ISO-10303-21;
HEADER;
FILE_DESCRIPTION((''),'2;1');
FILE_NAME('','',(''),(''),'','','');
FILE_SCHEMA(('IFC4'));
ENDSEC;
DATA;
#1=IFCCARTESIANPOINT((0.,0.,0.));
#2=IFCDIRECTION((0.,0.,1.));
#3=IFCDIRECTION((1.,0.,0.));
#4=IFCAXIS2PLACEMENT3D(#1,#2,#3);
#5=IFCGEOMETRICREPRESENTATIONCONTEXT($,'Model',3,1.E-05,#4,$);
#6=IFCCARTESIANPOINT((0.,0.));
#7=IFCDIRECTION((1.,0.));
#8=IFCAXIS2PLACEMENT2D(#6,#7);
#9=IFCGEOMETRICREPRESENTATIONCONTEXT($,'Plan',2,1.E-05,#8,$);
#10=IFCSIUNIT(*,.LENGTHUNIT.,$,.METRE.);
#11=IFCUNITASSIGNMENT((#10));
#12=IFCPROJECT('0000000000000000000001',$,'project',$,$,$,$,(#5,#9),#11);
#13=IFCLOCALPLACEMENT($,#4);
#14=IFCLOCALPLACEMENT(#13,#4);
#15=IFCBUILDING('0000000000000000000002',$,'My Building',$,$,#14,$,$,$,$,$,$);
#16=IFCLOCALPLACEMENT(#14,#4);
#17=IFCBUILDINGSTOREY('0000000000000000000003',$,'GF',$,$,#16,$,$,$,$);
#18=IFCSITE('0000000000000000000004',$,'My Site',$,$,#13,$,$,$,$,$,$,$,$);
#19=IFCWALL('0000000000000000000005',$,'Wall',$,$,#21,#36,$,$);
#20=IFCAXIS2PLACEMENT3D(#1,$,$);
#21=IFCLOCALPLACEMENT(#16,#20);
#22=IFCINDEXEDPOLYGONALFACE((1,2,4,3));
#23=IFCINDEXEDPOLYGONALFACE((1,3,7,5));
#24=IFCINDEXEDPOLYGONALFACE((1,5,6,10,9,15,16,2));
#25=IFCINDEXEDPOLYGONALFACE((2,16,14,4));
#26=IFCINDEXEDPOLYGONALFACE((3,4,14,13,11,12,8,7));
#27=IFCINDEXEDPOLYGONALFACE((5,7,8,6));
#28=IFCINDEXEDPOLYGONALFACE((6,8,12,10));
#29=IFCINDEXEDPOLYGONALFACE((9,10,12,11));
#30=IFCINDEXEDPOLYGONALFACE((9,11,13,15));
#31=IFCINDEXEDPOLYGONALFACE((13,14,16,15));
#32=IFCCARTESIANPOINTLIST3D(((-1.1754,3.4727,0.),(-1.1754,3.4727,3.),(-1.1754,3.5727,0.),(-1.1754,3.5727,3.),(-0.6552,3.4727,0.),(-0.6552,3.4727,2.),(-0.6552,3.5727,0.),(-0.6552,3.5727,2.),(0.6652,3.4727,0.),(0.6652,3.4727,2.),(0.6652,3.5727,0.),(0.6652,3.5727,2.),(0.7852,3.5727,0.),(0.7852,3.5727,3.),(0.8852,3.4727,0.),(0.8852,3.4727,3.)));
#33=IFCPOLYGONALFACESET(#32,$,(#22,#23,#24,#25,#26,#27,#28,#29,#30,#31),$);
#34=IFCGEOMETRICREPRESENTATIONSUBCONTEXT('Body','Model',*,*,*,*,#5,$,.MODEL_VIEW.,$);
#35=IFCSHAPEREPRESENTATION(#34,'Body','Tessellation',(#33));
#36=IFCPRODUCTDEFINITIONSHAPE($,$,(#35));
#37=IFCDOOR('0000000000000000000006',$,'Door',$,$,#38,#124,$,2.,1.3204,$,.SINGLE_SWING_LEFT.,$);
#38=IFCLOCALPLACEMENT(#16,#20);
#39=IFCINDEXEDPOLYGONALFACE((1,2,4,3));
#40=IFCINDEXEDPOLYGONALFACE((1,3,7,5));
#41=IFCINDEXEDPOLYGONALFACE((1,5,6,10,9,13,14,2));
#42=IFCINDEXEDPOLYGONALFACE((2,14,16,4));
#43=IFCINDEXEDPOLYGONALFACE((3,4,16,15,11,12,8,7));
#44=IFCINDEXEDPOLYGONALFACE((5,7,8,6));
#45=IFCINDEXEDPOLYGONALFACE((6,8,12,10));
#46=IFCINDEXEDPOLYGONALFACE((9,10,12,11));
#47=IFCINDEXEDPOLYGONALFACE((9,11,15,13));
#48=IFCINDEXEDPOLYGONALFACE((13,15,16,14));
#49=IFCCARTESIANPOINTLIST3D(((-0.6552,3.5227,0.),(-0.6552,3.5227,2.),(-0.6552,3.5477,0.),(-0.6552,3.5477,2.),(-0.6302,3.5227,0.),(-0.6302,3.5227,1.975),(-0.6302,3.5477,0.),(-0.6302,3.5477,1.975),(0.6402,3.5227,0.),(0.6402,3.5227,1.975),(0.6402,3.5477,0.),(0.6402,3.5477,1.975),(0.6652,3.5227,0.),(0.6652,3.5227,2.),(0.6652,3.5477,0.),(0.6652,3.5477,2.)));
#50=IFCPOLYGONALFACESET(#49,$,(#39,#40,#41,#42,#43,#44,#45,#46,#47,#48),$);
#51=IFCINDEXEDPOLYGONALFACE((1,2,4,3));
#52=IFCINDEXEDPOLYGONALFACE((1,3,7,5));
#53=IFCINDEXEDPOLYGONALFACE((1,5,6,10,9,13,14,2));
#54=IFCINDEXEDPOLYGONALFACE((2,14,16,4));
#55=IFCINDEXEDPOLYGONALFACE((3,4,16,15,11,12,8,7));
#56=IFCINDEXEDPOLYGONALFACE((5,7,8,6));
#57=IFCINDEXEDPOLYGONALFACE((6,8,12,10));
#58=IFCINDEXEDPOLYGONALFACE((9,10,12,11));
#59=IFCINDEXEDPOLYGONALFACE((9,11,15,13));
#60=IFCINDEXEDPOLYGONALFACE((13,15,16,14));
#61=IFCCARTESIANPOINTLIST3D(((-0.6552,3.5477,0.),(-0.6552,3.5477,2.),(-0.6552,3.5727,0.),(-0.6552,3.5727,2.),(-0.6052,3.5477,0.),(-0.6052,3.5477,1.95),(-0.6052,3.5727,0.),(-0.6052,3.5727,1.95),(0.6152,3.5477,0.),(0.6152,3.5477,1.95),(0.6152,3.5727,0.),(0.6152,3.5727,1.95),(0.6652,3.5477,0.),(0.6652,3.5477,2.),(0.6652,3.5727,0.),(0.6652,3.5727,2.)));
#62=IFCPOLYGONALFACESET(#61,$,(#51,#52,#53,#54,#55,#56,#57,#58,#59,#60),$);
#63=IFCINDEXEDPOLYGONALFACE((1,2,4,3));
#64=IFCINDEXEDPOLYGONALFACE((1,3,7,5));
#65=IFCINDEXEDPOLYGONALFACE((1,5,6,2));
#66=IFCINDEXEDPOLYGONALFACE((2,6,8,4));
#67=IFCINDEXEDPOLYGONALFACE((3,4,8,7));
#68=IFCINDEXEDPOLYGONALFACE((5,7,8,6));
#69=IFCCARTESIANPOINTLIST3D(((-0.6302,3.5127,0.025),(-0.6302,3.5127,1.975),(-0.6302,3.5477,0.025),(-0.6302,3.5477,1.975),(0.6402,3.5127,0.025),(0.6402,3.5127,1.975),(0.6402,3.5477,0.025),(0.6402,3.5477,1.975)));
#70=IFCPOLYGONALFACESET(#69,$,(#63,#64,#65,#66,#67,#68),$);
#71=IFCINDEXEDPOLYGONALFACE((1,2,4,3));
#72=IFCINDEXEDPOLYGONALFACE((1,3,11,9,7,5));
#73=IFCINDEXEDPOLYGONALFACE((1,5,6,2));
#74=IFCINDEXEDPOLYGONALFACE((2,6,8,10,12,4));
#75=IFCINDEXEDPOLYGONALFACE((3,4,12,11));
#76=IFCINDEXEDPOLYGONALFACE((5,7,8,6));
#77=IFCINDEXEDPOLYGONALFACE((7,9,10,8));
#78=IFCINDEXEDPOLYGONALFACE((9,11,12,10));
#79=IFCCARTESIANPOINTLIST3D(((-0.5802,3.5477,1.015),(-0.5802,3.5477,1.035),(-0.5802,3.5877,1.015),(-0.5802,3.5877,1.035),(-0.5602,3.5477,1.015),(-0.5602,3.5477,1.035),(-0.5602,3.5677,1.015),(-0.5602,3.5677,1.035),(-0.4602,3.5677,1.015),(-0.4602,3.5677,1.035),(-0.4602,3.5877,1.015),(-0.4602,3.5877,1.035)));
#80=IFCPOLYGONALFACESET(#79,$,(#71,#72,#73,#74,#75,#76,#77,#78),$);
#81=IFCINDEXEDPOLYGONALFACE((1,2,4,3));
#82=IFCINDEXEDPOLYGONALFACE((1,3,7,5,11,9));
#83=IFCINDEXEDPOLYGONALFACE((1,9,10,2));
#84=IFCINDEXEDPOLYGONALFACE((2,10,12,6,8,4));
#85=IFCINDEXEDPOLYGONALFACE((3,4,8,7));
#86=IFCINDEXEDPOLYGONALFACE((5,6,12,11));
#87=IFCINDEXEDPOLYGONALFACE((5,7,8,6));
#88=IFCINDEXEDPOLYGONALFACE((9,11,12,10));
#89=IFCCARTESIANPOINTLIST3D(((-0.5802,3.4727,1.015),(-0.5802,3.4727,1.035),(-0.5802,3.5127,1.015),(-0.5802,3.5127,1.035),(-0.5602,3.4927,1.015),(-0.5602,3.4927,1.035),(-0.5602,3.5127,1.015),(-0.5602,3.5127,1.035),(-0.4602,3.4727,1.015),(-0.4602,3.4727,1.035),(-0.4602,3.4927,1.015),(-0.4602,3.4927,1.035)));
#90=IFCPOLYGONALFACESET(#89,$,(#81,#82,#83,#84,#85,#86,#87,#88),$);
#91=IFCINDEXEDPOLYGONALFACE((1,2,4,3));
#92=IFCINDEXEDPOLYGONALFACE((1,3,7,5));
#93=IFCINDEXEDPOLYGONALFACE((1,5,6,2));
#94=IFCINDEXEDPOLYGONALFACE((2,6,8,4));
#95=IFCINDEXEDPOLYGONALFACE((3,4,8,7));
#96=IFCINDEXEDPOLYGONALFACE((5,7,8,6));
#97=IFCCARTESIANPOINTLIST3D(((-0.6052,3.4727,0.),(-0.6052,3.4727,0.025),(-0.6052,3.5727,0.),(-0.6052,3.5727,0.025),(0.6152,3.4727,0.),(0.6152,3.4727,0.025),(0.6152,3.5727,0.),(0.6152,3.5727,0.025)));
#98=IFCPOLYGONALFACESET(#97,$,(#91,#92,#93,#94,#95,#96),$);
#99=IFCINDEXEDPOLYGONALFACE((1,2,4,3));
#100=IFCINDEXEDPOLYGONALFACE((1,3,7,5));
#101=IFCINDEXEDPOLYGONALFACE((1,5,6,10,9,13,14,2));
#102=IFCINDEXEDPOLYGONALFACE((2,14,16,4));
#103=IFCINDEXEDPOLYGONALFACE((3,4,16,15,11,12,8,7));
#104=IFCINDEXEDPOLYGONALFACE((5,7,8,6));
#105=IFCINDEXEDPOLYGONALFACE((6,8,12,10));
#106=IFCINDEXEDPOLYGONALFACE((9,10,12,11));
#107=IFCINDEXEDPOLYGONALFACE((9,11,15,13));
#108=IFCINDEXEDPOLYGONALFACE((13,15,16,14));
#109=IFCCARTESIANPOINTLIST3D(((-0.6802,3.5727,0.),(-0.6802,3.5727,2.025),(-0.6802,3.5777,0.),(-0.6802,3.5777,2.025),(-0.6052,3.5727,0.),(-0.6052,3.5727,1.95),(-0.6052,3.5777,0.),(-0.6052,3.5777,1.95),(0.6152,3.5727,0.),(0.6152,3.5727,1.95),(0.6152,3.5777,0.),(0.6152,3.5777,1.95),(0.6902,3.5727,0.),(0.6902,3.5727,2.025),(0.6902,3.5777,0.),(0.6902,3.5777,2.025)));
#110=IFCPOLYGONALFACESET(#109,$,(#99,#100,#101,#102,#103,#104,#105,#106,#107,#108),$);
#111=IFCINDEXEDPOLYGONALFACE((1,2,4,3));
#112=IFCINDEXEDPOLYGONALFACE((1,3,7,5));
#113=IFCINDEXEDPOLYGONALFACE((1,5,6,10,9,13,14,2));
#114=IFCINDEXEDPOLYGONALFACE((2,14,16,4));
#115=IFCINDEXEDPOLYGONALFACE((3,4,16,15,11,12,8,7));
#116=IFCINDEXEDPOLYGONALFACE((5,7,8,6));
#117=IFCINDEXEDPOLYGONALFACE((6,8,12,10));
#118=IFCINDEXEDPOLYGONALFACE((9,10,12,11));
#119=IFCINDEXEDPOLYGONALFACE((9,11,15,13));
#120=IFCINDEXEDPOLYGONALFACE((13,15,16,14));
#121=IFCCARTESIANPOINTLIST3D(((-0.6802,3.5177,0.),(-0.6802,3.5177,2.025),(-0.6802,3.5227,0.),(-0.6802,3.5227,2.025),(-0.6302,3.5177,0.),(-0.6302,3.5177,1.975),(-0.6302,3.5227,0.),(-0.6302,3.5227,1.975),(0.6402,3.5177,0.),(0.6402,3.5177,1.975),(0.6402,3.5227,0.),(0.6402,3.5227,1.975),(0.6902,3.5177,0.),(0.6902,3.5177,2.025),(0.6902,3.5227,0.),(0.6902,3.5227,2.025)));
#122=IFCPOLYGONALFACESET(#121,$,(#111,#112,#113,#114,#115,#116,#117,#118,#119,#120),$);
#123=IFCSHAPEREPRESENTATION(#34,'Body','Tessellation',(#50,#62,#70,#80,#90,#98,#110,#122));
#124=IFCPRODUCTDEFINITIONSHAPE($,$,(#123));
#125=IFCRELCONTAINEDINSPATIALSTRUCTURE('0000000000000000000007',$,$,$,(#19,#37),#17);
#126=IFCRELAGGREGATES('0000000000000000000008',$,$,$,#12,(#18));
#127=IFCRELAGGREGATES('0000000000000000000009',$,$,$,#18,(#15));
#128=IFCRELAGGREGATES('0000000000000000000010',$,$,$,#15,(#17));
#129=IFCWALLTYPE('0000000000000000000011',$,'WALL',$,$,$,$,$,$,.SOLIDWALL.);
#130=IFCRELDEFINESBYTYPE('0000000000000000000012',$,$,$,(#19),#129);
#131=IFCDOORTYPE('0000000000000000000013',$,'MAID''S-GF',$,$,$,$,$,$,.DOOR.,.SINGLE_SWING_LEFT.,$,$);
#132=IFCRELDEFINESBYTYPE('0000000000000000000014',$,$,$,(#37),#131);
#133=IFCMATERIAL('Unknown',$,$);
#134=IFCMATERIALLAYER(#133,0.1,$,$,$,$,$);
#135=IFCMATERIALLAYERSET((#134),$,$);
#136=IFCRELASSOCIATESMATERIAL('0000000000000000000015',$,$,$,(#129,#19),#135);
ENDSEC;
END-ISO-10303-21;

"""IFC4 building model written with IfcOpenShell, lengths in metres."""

from ifc_helpers import new_model, entity, si_unit, frame, origin_with_axes, origin_2d_with_axis, place, context, subcontext, project, spatial, line, indexed_curve, outline, extrude, shape, source, transform, mapped, material, layer, layer_set, layer_usage, type_object, type_shapes, element, fill, save


model = new_model("IFC4")

# Units and contexts
model_context = context("Model", 3, precision=1e-05, world=origin_with_axes())
plan_context = context("Plan", 2, precision=1e-05, world=origin_2d_with_axis())
body_context_1 = subcontext(model_context, "Body", "Model", "MODEL_VIEW")
body_context_2 = subcontext(plan_context, "Body", "Plan", "PLAN_VIEW")
ifc_project = project(units=[si_unit("LENGTHUNIT", "METRE")], contexts=[model_context, plan_context])

# Site, building, storey
site_placement = place(None, origin_with_axes())
site = spatial("IfcSite", under=ifc_project, at=site_placement, Name="My Site")
building_placement = place(site_placement, origin_with_axes())
building = spatial("IfcBuilding", under=site, at=building_placement, Name="My Building")
storey_placement = place(building_placement, origin_with_axes())
storey = spatial("IfcBuildingStorey", under=building, at=storey_placement, Name="GF")

# Shared definitions
ifc_material_1 = material(Name="Unknown")

# Shared definitions
ifc_layer_1 = layer(ifc_material_1, 0.1)
ifc_layer_set_1 = layer_set([ifc_layer_1])
wall_type = type_object("IfcWallType", Name="WALL", PredefinedType="SOLIDWALL", material=ifc_layer_set_1)

# Wall, opening, door
ifc_layer_usage_1 = layer_usage(ifc_layer_set_1, "AXIS2", "POSITIVE", 0.0)
wall_1_placement = place(storey_placement, frame((0.7852, 3.5727, 0.0), z_axis=(0.0, 0.0, 1.0), x_axis=(-1.0, 0.0, 0.0)))
wall_1 = element("IfcWall", 1, at=wall_1_placement, inside=storey, type_object=wall_type, material=ifc_layer_usage_1, Name="Wall", context=body_context_1, shape_type="SweptSolid", body=[
    extrude(outline(indexed_curve([(0.0, 0.0), (-0.1, 0.1), (1.9606, 0.1), (1.9606, 0.0)], segments=[line(1, 2, 3, 4, 1)])), origin_with_axes(), (0.0, 0.0, 1.0), 3.0),
])
shared_shape_1 = source(origin_with_axes(), body_context_1, "Body", "SweptSolid", [
    extrude(outline(indexed_curve([(0.0, 0.0), (1.3204, 0.0), (1.3204, 2.0), (0.0, 2.0)], segments=[line(1, 2, 3, 4, 1)])), frame((0.0, -0.6, 0.0), z_axis=(0.0, -1.0, 0.0), x_axis=(1.0, 0.0, 0.0)), (0.0, 0.0, -1.0), 1.2),
])
opening_1_placement = place(wall_1_placement, frame((0.12, 0.0, 0.0), z_axis=(0.0, 0.0, 1.0), x_axis=(1.0, 0.0, 0.0)))
opening_1 = element("IfcOpeningElement", 2, at=opening_1_placement, cuts=wall_1, PredefinedType="OPENING", context=body_context_1, shape_type="MappedRepresentation", body=[
    mapped(shared_shape_1, transform((0.0, 0.0, 0.0), x_axis=(1.0, 0.0, 0.0), y_axis=(0.0, 1.0, 0.0), z_axis=(0.0, 0.0, 1.0), scale=1.0)),
])
door_type_1 = type_object("IfcDoorType", Name="MAID'S-GF", OperationType="SINGLE_SWING_LEFT", PredefinedType="DOOR")
shared_shape_2 = source(origin_with_axes(), body_context_1, "Body", "SweptSolid", [
    extrude(outline(indexed_curve([(0.0, 0.0), (0.0, 2.0), (1.3204, 2.0), (1.3204, 0.0), (1.2954, 0.0), (1.2954, 1.975), (0.025, 1.975), (0.025, 0.0)], segments=[line(1, 2, 3, 4, 5, 6, 7, 8, 1)])), frame((0.0, 0.025, 0.0), z_axis=(0.0, -1.0, 0.0), x_axis=(1.0, 0.0, 0.0)), (0.0, 0.0, -1.0), 0.025),
    extrude(outline(indexed_curve([(0.0, 0.0), (0.0, 2.0), (1.3204, 2.0), (1.3204, 0.0), (1.2704, 0.0), (1.2704, 1.95), (0.05, 1.95), (0.05, 0.0)], segments=[line(1, 2, 3, 4, 5, 6, 7, 8, 1)])), frame((0.0, 0.0, 0.0), z_axis=(0.0, -1.0, 0.0), x_axis=(1.0, 0.0, 0.0)), (0.0, 0.0, -1.0), 0.025),
    extrude(outline(indexed_curve([(0.0, 0.0), (1.2704, 0.0), (1.2704, 0.035), (0.0, 0.035)], segments=[line(1, 2, 3, 4, 1)])), frame((0.025, 0.025, 0.025), z_axis=(0.0, 0.0, 1.0), x_axis=(1.0, 0.0, 0.0)), (0.0, 0.0, 1.0), 1.95),
    extrude(outline(indexed_curve([(0.0, 0.0), (0.0, -0.04), (-0.12, -0.04), (-0.12, -0.02), (-0.02, -0.02), (-0.02, 0.0)], segments=[line(1, 2, 3, 4, 5, 6, 1)])), frame((1.2454, 0.025, 1.015), z_axis=(0.0, 0.0, 1.0), x_axis=(1.0, 0.0, 0.0)), (0.0, 0.0, 1.0), 0.02),
    extrude(outline(indexed_curve([(0.0, 0.0), (0.0, 0.04), (-0.12, 0.04), (-0.12, 0.02), (-0.02, 0.02), (-0.02, 0.0)], segments=[line(1, 2, 3, 4, 5, 6, 1)])), frame((1.2454, 0.06, 1.015), z_axis=(0.0, 0.0, 1.0), x_axis=(1.0, 0.0, 0.0)), (0.0, 0.0, 1.0), 0.02),
    extrude(outline(indexed_curve([(0.0, 0.0), (1.2204, 0.0), (1.2204, 0.1), (0.0, 0.1)], segments=[line(1, 2, 3, 4, 1)])), frame((0.05, 0.0, 0.0), z_axis=(0.0, 0.0, 1.0), x_axis=(1.0, 0.0, 0.0)), (0.0, 0.0, 1.0), 0.025),
    extrude(outline(indexed_curve([(0.0, 0.0), (0.0, 2.025), (1.3704, 2.025), (1.3704, 0.0), (1.2954, 0.0), (1.2954, 1.95), (0.075, 1.95), (0.075, 0.0)], segments=[line(1, 2, 3, 4, 5, 6, 7, 8, 1)])), frame((-0.025, -0.005, 0.0), z_axis=(0.0, -1.0, 0.0), x_axis=(1.0, 0.0, 0.0)), (0.0, 0.0, -1.0), 0.005),
    extrude(outline(indexed_curve([(0.0, 0.0), (0.0, 2.025), (1.3704, 2.025), (1.3704, 0.0), (1.3204, 0.0), (1.3204, 1.975), (0.05, 1.975), (0.05, 0.0)], segments=[line(1, 2, 3, 4, 5, 6, 7, 8, 1)])), frame((-0.025, 0.05, 0.0), z_axis=(0.0, -1.0, 0.0), x_axis=(1.0, 0.0, 0.0)), (0.0, 0.0, -1.0), 0.005),
])
shared_shape_3 = source(origin_with_axes(), body_context_2, "Body", "Curve2D", [
    entity("IfcIndexedPolyCurve", entity("IfcCartesianPointList2D", [[0.0, 0.0], [0.0, 0.05], [0.025, 0.05], [0.025, 0.025], [0.05, 0.025], [0.05, 0.0]]), [entity("IfcLineIndex", [1, 2, 3, 4, 5, 6, 1])]),
    entity("IfcIndexedPolyCurve", entity("IfcCartesianPointList2D", [[1.3204, 0.0], [1.3204, 0.05], [1.2954, 0.05], [1.2954, 0.025], [1.2704, 0.025], [1.2704, 0.0]]), [entity("IfcLineIndex", [1, 2, 3, 4, 5, 6, 1])]),
    entity("IfcTrimmedCurve", entity("IfcEllipse", entity("IfcAxis2Placement2D", entity("IfcCartesianPoint", [0.06, 0.05]), entity("IfcDirection", [1.0, 0.0])), 1.2354, 1.2704), [entity("IfcCartesianPoint", [1.2954, 0.05])], [entity("IfcCartesianPoint", [0.06, 1.3204])], True, "CARTESIAN"),
    entity("IfcIndexedPolyCurve", entity("IfcCartesianPointList2D", [[0.025, 0.05], [0.06, 0.05], [0.06, 1.3204], [0.025, 1.3204]]), [entity("IfcLineIndex", [1, 2, 3, 4, 1])]),
])
type_shapes(door_type_1, [shared_shape_2, shared_shape_3])
door_1_placement = place(opening_1_placement, frame((0.0, 0.0, 0.0), z_axis=(0.0, 0.0, 1.0), x_axis=(1.0, 0.0, 0.0)))
door_1 = element("IfcDoor", 3, at=door_1_placement, inside=storey, type_object=door_type_1, Name="Door", OperationType="SINGLE_SWING_LEFT", OverallHeight=2.0, OverallWidth=1.3204, shapes=[
    shape(body_context_1, "Body", "MappedRepresentation", [mapped(shared_shape_2, transform((0.0, 0.0, 0.0), x_axis=(1.0, 0.0, 0.0), y_axis=(0.0, 1.0, 0.0), z_axis=(0.0, 0.0, 1.0), scale=1.0))]),
    shape(body_context_2, "Body", "MappedRepresentation", [mapped(shared_shape_3, transform((0.0, 0.0, 0.0), x_axis=(1.0, 0.0, 0.0), y_axis=(0.0, 1.0, 0.0), z_axis=(0.0, 0.0, 1.0), scale=1.0))]),
])
fill(opening_1, door_1)

save(model, "model.ifc")
